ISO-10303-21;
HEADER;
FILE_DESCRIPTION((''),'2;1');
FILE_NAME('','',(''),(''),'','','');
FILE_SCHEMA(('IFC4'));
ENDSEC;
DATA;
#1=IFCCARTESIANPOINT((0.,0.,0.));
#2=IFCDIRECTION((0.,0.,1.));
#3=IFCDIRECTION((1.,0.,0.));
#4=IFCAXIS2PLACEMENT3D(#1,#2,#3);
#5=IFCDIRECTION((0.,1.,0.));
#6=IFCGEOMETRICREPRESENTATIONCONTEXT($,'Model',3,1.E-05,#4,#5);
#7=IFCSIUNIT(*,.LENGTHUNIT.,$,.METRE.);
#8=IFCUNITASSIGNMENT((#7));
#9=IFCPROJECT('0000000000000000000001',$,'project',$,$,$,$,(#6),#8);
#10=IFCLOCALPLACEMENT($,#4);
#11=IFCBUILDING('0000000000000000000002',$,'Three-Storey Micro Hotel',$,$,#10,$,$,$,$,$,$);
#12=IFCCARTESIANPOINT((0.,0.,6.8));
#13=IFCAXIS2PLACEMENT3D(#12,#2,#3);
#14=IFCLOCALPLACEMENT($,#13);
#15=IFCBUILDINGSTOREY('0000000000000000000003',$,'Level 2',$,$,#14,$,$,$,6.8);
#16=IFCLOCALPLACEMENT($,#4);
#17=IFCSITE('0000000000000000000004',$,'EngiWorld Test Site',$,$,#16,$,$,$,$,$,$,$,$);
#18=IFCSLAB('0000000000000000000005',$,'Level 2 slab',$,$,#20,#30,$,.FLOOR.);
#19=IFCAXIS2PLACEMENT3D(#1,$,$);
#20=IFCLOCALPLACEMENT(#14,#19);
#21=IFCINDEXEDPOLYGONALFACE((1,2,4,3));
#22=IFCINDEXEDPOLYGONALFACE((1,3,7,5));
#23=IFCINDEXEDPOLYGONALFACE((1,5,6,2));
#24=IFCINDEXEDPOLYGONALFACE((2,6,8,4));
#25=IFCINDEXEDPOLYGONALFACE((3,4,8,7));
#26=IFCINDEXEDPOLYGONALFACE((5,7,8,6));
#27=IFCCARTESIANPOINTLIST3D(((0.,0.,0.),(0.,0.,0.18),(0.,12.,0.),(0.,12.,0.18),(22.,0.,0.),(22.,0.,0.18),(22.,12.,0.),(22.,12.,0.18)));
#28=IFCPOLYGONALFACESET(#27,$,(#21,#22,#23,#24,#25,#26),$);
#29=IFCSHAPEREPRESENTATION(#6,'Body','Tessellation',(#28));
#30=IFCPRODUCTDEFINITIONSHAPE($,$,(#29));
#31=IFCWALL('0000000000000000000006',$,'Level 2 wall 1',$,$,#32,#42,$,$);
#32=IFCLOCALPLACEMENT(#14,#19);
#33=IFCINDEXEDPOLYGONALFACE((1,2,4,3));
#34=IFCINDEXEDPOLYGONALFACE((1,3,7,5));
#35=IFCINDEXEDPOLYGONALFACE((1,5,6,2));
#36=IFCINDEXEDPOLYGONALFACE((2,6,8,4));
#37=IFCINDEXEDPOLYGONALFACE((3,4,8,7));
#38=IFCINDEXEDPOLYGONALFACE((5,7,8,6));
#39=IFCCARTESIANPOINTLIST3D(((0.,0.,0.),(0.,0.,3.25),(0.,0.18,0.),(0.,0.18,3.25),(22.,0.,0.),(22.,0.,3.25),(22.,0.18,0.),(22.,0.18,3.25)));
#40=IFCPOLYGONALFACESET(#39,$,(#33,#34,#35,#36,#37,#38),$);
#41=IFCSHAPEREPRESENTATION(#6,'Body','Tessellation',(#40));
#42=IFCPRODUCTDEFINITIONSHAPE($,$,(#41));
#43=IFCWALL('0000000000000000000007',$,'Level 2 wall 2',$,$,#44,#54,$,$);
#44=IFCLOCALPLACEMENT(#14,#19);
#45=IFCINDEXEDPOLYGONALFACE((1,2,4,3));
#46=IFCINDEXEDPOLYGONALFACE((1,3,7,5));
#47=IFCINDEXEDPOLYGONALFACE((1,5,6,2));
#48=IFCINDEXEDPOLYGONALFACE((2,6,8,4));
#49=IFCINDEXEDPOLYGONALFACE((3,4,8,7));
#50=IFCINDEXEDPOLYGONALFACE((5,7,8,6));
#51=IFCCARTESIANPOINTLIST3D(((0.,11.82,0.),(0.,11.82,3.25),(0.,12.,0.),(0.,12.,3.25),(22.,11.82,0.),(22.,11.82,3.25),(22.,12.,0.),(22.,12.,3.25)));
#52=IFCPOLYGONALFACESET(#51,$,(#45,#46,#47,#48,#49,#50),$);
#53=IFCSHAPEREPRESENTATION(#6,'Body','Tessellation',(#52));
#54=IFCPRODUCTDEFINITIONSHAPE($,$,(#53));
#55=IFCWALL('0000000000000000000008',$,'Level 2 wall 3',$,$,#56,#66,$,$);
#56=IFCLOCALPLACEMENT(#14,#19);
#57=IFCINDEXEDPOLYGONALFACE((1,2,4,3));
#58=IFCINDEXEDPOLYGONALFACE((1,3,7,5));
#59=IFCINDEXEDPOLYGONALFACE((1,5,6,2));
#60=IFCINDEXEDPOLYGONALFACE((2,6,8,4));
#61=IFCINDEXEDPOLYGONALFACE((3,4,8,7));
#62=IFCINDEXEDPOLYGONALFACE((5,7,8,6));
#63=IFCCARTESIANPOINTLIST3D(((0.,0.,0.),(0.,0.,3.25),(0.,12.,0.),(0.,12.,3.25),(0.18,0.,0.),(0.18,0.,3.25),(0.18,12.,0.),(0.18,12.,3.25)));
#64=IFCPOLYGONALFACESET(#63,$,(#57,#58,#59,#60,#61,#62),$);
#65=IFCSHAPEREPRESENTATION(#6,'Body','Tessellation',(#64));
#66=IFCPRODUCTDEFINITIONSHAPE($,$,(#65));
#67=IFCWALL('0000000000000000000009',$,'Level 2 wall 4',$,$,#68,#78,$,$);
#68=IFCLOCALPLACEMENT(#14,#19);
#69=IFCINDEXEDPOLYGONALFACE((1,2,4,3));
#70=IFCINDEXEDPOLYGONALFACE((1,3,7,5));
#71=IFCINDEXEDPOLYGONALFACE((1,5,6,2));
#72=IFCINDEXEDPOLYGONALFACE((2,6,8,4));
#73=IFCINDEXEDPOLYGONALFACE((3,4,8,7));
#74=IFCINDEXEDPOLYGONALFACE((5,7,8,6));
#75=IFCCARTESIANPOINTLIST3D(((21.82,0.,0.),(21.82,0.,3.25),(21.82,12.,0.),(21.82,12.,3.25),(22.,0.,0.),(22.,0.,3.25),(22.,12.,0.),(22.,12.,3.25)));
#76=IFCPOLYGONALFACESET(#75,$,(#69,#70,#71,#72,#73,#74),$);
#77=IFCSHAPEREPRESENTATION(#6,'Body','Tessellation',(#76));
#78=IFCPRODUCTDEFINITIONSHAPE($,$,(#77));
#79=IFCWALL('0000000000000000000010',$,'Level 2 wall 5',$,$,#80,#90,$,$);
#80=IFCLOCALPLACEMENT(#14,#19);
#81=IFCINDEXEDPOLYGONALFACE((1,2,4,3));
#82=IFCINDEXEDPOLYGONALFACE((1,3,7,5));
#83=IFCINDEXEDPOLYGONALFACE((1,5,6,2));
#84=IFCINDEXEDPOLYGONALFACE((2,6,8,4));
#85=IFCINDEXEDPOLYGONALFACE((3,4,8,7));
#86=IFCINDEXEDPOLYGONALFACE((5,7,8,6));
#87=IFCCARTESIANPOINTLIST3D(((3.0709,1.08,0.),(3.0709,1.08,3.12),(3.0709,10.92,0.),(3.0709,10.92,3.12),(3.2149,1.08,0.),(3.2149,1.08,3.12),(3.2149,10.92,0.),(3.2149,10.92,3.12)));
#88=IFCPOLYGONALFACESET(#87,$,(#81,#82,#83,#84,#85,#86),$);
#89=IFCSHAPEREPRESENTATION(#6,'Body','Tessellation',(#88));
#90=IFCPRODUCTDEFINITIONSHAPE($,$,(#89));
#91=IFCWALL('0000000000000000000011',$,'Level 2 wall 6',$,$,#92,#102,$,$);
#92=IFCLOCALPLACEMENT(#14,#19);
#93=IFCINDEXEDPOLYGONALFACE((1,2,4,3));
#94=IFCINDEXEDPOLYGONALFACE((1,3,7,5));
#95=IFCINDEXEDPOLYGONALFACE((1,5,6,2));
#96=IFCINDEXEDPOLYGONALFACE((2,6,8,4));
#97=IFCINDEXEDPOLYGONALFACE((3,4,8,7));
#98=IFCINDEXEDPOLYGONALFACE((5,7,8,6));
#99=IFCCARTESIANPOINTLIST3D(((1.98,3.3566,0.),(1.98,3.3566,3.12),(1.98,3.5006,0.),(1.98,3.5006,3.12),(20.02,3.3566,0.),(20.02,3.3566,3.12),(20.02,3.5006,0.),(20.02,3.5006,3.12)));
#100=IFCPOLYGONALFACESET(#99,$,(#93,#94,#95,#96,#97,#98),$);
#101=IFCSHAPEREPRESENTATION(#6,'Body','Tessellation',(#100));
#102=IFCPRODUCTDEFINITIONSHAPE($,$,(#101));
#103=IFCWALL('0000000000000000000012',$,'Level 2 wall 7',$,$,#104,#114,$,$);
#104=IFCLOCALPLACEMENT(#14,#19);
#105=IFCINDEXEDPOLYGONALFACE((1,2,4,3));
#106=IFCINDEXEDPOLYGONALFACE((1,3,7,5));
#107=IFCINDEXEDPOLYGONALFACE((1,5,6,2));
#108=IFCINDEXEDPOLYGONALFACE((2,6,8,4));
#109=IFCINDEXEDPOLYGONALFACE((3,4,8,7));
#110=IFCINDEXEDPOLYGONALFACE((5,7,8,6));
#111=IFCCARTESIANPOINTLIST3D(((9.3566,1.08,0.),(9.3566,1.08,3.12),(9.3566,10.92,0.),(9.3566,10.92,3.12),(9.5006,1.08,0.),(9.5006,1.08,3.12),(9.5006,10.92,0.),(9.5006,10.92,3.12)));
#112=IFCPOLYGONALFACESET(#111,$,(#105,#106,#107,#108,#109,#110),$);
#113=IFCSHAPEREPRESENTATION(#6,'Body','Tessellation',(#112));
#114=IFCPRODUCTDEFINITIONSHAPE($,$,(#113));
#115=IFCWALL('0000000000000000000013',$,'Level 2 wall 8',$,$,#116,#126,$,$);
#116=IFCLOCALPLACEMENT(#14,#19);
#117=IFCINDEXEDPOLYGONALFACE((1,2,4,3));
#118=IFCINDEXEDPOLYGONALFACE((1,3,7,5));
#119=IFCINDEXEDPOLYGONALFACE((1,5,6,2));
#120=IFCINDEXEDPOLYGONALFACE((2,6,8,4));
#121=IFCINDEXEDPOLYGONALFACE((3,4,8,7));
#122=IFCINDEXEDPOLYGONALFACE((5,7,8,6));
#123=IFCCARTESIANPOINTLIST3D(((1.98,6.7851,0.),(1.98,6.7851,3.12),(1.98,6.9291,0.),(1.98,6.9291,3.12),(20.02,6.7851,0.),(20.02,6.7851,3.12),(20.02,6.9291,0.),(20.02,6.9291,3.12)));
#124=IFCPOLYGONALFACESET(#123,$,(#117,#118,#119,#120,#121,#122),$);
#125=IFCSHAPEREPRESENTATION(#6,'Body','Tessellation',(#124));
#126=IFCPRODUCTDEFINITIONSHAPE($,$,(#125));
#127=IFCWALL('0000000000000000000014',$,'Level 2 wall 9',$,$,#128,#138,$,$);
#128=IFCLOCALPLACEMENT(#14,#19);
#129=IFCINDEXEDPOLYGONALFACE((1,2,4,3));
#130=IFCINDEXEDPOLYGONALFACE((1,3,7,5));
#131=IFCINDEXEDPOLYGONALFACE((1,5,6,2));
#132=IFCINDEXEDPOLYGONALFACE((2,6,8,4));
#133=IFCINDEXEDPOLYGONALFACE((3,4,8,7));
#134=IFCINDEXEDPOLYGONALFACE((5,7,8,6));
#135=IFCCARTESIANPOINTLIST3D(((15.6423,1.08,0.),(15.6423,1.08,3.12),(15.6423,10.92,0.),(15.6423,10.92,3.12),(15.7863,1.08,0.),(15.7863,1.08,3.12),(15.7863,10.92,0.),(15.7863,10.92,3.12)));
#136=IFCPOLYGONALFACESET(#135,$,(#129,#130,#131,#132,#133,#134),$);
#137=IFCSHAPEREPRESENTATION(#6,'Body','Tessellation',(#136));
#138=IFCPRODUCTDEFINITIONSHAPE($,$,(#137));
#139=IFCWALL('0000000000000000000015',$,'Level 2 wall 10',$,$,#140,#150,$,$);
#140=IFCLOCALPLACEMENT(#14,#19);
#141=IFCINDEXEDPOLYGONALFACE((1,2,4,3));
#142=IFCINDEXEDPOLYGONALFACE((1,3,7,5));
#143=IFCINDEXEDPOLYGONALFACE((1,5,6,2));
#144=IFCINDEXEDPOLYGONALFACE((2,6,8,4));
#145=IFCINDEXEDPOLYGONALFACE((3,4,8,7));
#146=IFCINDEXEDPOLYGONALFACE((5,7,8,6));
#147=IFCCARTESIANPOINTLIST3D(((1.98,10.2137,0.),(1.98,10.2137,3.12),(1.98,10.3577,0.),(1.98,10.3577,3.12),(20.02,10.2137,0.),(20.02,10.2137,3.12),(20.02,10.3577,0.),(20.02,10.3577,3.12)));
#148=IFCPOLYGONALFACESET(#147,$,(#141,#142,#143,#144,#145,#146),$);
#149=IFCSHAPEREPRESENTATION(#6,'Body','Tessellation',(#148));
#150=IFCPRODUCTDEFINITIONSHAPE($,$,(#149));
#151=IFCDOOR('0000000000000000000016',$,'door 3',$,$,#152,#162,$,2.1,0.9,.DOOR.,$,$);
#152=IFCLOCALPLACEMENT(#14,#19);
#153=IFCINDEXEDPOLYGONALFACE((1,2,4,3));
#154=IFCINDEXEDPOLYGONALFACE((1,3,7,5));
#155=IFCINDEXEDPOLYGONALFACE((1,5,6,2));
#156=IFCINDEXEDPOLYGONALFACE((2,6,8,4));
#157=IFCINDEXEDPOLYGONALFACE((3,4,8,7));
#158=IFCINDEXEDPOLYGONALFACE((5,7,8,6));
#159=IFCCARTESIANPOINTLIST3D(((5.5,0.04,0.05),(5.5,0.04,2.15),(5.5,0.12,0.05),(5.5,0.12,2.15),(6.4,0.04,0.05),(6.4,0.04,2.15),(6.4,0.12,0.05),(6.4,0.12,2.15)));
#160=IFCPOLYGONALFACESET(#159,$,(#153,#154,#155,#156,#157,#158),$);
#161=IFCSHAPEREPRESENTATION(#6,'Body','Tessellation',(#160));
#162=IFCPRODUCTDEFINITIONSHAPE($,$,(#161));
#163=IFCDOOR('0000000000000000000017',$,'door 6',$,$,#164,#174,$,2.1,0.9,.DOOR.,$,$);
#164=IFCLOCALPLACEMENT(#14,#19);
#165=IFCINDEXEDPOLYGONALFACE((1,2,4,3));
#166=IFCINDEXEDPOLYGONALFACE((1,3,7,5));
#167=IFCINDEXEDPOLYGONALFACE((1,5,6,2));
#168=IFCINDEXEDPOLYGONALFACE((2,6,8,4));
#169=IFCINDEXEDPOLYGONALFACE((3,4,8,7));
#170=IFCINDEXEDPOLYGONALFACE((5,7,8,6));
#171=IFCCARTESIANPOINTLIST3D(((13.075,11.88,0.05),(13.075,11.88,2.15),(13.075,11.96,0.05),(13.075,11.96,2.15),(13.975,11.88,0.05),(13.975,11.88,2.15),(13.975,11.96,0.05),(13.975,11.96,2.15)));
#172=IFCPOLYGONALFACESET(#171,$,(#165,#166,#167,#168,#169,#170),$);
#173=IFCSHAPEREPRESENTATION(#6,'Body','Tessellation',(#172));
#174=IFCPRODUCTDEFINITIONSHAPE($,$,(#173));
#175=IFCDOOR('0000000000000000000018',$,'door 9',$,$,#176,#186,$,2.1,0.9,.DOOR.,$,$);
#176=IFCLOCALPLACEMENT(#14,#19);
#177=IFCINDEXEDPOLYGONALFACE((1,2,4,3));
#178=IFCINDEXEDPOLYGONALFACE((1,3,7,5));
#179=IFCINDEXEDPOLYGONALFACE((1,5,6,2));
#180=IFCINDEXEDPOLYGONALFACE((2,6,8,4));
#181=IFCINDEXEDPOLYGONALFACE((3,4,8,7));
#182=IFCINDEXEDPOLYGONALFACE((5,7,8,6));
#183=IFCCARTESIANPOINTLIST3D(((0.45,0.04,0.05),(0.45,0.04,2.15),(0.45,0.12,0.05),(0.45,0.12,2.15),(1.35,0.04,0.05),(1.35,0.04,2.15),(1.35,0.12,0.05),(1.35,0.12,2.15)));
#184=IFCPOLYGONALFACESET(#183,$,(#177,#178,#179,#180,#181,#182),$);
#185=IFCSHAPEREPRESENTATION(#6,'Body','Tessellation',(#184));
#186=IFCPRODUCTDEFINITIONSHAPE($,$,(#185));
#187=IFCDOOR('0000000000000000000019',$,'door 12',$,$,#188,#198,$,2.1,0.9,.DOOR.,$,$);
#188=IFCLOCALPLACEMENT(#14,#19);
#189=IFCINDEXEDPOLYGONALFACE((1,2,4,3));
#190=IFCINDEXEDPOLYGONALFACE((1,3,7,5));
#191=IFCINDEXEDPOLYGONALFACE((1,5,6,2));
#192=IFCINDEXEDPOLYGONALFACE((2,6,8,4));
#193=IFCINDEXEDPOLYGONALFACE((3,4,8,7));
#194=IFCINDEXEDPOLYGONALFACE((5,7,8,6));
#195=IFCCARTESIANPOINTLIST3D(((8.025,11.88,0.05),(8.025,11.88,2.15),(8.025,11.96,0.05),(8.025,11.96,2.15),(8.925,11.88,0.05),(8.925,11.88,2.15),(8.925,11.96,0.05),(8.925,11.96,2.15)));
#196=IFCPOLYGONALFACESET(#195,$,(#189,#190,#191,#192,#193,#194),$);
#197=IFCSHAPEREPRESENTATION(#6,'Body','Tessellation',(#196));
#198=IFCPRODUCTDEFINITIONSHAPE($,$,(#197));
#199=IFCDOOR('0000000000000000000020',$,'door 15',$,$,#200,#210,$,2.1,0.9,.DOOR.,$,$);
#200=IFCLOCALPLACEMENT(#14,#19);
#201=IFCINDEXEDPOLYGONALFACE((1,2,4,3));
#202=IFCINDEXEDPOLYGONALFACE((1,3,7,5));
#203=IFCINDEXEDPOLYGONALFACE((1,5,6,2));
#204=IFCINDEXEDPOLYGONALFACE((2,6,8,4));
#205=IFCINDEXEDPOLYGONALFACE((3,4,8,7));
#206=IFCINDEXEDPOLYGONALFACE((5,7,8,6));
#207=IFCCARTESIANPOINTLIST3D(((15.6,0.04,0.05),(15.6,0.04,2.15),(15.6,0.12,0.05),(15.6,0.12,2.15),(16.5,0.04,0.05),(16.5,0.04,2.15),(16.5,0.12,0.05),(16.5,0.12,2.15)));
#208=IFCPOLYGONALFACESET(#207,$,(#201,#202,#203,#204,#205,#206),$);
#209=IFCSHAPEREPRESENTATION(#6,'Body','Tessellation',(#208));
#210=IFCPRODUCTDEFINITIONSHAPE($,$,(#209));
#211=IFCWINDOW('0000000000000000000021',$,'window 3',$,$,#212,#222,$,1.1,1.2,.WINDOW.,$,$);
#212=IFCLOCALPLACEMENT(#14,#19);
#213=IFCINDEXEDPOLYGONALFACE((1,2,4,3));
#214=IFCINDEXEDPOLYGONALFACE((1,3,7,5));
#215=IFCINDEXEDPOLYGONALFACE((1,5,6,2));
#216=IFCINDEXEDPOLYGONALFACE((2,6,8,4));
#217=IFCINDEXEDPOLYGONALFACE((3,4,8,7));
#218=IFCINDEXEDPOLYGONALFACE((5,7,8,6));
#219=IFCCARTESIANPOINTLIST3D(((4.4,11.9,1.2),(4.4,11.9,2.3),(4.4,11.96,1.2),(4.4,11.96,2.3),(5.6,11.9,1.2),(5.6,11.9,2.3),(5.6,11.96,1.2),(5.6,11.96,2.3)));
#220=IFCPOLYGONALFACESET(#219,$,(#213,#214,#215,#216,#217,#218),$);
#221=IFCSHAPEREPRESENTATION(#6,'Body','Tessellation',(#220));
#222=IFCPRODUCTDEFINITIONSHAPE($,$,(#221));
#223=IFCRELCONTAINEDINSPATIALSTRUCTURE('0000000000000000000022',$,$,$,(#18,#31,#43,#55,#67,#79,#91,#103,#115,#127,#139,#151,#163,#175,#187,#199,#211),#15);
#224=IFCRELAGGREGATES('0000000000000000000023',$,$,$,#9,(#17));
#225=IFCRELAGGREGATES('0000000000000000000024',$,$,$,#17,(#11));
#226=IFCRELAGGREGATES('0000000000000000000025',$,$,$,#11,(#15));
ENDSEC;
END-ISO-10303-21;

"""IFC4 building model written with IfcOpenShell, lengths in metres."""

from ifc_helpers import new_model, si_unit, direction, frame, origin_with_axes, origin_2d_with_axis, place, context, project, spatial, rectangle, extrude, element, save


model = new_model("IFC4")

# Units and contexts
model_context = context("Model", 3, precision=1e-05, world=origin_with_axes(), true_north=direction((0.0, 1.0, 0.0)))
ifc_project = project(units=[si_unit("LENGTHUNIT", "METRE")], contexts=[model_context])

# Site, building, storey
site_placement = place(None, origin_with_axes())
site = spatial("IfcSite", under=ifc_project, at=site_placement, Name="EngiWorld Test Site")
building_placement = place(None, origin_with_axes())
building = spatial("IfcBuilding", under=site, at=building_placement, Name="Three-Storey Micro Hotel")
storey_placement = place(None, frame((0.0, 0.0, 6.8), z_axis=(0.0, 0.0, 1.0), x_axis=(1.0, 0.0, 0.0)))
storey = spatial("IfcBuildingStorey", under=building, at=storey_placement, Name="Level 2", Elevation=6.8)

# Slab
slab_placement = place(None, frame((11.0, 6.0, 6.8), z_axis=(0.0, 0.0, 1.0), x_axis=(1.0, 0.0, 0.0)))
element("IfcSlab", 1, at=slab_placement, inside=storey, Name="Level 2 slab", PredefinedType="FLOOR", context=model_context, shape_type="SweptSolid", body=[
    extrude(rectangle(XDim=22.0, YDim=12.0, at=origin_2d_with_axis()), origin_with_axes(), (0.0, 0.0, 1.0), 0.18),
])

# Walls
for number, where, z_axis, x_axis, name in (
    (2, (11.0, 0.09, 6.8), (0.0, 0.0, 1.0), (1.0, 0.0, 0.0), "Level 2 wall 1"),
    (3, (11.0, 11.91, 6.8), (0.0, 0.0, 1.0), (1.0, 0.0, 0.0), "Level 2 wall 2"),
):
    element("IfcWall", number, at=place(None, frame(where, z_axis=z_axis, x_axis=x_axis)), inside=storey, Name=name, context=model_context, shape_type="SweptSolid", body=[
        extrude(rectangle(XDim=22.0, YDim=0.18, at=origin_2d_with_axis()), origin_with_axes(), (0.0, 0.0, 1.0), 3.25),
    ])
for number, where, z_axis, x_axis, name in (
    (4, (0.09, 6.0, 6.8), (0.0, 0.0, 1.0), (1.0, 0.0, 0.0), "Level 2 wall 3"),
    (5, (21.91, 6.0, 6.8), (0.0, 0.0, 1.0), (1.0, 0.0, 0.0), "Level 2 wall 4"),
):
    element("IfcWall", number, at=place(None, frame(where, z_axis=z_axis, x_axis=x_axis)), inside=storey, Name=name, context=model_context, shape_type="SweptSolid", body=[
        extrude(rectangle(XDim=0.18, YDim=12.0, at=origin_2d_with_axis()), origin_with_axes(), (0.0, 0.0, 1.0), 3.25),
    ])
wall_1_placement = place(None, frame((3.1429, 6.0, 6.8), z_axis=(0.0, 0.0, 1.0), x_axis=(1.0, 0.0, 0.0)))
element("IfcWall", 6, at=wall_1_placement, inside=storey, Name="Level 2 wall 5", context=model_context, shape_type="SweptSolid", body=[
    extrude(rectangle(XDim=0.144, YDim=9.84, at=origin_2d_with_axis()), origin_with_axes(), (0.0, 0.0, 1.0), 3.12),
])
wall_2_placement = place(None, frame((11.0, 3.4286, 6.8), z_axis=(0.0, 0.0, 1.0), x_axis=(1.0, 0.0, 0.0)))
element("IfcWall", 7, at=wall_2_placement, inside=storey, Name="Level 2 wall 6", context=model_context, shape_type="SweptSolid", body=[
    extrude(rectangle(XDim=18.04, YDim=0.144, at=origin_2d_with_axis()), origin_with_axes(), (0.0, 0.0, 1.0), 3.12),
])
wall_3_placement = place(None, frame((9.4286, 6.0, 6.8), z_axis=(0.0, 0.0, 1.0), x_axis=(1.0, 0.0, 0.0)))
element("IfcWall", 8, at=wall_3_placement, inside=storey, Name="Level 2 wall 7", context=model_context, shape_type="SweptSolid", body=[
    extrude(rectangle(XDim=0.144, YDim=9.84, at=origin_2d_with_axis()), origin_with_axes(), (0.0, 0.0, 1.0), 3.12),
])
wall_4_placement = place(None, frame((11.0, 6.8571, 6.8), z_axis=(0.0, 0.0, 1.0), x_axis=(1.0, 0.0, 0.0)))
element("IfcWall", 9, at=wall_4_placement, inside=storey, Name="Level 2 wall 8", context=model_context, shape_type="SweptSolid", body=[
    extrude(rectangle(XDim=18.04, YDim=0.144, at=origin_2d_with_axis()), origin_with_axes(), (0.0, 0.0, 1.0), 3.12),
])
wall_5_placement = place(None, frame((15.7143, 6.0, 6.8), z_axis=(0.0, 0.0, 1.0), x_axis=(1.0, 0.0, 0.0)))
element("IfcWall", 10, at=wall_5_placement, inside=storey, Name="Level 2 wall 9", context=model_context, shape_type="SweptSolid", body=[
    extrude(rectangle(XDim=0.144, YDim=9.84, at=origin_2d_with_axis()), origin_with_axes(), (0.0, 0.0, 1.0), 3.12),
])
wall_6_placement = place(None, frame((11.0, 10.2857, 6.8), z_axis=(0.0, 0.0, 1.0), x_axis=(1.0, 0.0, 0.0)))
element("IfcWall", 11, at=wall_6_placement, inside=storey, Name="Level 2 wall 10", context=model_context, shape_type="SweptSolid", body=[
    extrude(rectangle(XDim=18.04, YDim=0.144, at=origin_2d_with_axis()), origin_with_axes(), (0.0, 0.0, 1.0), 3.12),
])

# Doors
for number, where, z_axis, x_axis, name in (
    (12, (5.95, 0.08, 6.85), (0.0, 0.0, 1.0), (1.0, 0.0, 0.0), "door 3"),
    (13, (13.525, 11.92, 6.85), (0.0, 0.0, 1.0), (1.0, 0.0, 0.0), "door 6"),
    (14, (0.9, 0.08, 6.85), (0.0, 0.0, 1.0), (1.0, 0.0, 0.0), "door 9"),
    (15, (8.475, 11.92, 6.85), (0.0, 0.0, 1.0), (1.0, 0.0, 0.0), "door 12"),
    (16, (16.05, 0.08, 6.85), (0.0, 0.0, 1.0), (1.0, 0.0, 0.0), "door 15"),
):
    element("IfcDoor", number, at=place(None, frame(where, z_axis=z_axis, x_axis=x_axis)), inside=storey, Name=name, OverallHeight=2.1, OverallWidth=0.9, PredefinedType="DOOR", context=model_context, shape_type="SweptSolid", body=[
        extrude(rectangle(XDim=0.9, YDim=0.08, at=origin_2d_with_axis()), origin_with_axes(), (0.0, 0.0, 1.0), 2.1),
    ])

# Window
for number, where, z_axis, x_axis, name in (
    (17, (5.0, 11.93, 8.0), (0.0, 0.0, 1.0), (1.0, 0.0, 0.0), "window 3"),
):
    element("IfcWindow", number, at=place(None, frame(where, z_axis=z_axis, x_axis=x_axis)), inside=storey, Name=name, OverallHeight=1.1, OverallWidth=1.2, PredefinedType="WINDOW", context=model_context, shape_type="SweptSolid", body=[
        extrude(rectangle(XDim=1.2, YDim=0.06, at=origin_2d_with_axis()), origin_with_axes(), (0.0, 0.0, 1.0), 1.1),
    ])

save(model, "model.ifc")
